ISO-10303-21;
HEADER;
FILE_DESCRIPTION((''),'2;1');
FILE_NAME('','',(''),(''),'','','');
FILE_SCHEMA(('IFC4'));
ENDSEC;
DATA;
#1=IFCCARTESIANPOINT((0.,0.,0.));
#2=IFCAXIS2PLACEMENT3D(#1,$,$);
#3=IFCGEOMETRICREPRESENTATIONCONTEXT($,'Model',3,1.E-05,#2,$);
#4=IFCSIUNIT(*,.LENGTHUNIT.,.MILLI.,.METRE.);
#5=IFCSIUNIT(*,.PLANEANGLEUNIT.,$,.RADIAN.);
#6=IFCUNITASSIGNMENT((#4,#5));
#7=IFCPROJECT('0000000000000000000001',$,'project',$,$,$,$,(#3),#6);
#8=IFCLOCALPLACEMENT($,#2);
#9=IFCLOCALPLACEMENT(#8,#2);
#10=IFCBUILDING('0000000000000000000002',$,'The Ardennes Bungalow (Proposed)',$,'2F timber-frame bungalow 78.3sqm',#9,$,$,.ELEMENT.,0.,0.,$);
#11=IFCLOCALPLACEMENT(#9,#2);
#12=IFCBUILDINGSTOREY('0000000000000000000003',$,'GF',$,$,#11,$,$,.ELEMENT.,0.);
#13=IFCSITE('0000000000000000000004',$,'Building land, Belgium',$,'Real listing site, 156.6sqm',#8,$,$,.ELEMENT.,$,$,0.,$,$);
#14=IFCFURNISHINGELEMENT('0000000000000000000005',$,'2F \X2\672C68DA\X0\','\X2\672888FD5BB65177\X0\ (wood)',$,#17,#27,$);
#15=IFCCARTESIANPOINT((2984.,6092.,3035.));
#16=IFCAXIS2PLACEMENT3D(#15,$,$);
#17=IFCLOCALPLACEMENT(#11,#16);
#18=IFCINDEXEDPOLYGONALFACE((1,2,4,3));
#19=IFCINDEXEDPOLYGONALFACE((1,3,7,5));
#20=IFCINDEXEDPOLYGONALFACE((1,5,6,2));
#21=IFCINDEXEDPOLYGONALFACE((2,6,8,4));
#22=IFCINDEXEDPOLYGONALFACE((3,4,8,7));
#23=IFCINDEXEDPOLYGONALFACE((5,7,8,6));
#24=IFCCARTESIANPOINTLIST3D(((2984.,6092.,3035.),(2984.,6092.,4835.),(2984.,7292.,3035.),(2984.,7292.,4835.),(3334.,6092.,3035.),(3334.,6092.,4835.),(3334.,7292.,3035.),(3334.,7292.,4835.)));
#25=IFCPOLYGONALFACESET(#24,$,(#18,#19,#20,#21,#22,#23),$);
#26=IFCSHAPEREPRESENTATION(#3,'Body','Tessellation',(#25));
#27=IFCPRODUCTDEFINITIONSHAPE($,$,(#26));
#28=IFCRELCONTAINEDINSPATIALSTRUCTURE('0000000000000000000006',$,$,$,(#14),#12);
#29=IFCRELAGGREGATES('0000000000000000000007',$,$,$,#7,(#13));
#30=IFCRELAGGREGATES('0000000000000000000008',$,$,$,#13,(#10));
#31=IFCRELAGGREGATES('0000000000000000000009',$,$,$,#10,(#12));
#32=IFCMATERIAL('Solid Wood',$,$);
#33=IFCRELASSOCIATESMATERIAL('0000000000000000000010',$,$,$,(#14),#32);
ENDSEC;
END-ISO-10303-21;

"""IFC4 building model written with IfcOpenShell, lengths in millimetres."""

from ifc_helpers import new_model, si_unit, frame, frame_2d, origin, place, context, project, spatial, rectangle, extrude, material, element, save


model = new_model("IFC4")

# Units and contexts
model_context = context("Model", 3, precision=1e-05, world=origin())
ifc_project = project(units=[si_unit("LENGTHUNIT", "METRE", prefix="MILLI"), si_unit("PLANEANGLEUNIT", "RADIAN")], contexts=[model_context])

# Site, building, storey
site_placement = place(None, origin())
site = spatial("IfcSite", under=ifc_project, at=site_placement, Name="Building land, Belgium", ObjectType="Real listing site, 156.6sqm", CompositionType="ELEMENT", RefElevation=0.0)
building_placement = place(site_placement, origin())
building = spatial("IfcBuilding", under=site, at=building_placement, Name="The Ardennes Bungalow (Proposed)", ObjectType="2F timber-frame bungalow 78.3sqm", CompositionType="ELEMENT", ElevationOfRefHeight=0.0, ElevationOfTerrain=0.0)
storey_placement = place(building_placement, origin())
storey = spatial("IfcBuildingStorey", under=building, at=storey_placement, Name="GF", CompositionType="ELEMENT", Elevation=0.0)

# Shared definitions
ifc_material_1 = material(Name="Solid Wood")

# Furnishing element
furnishing_1_placement = place(storey_placement, frame((2984.0, 6092.0, 3035.0)))
element("IfcFurnishingElement", 1, at=furnishing_1_placement, inside=storey, material=ifc_material_1, Name="2F 本棚", Description="木製家具 (wood)", context=model_context, shape_type="SweptSolid", body=[
    extrude(rectangle(XDim=350.0, YDim=1200.0, at=frame_2d((175.0, 600.0))), frame((2984.0, 6092.0, 3035.0)), (0.0, 0.0, 1.0), 1800.0),
])

save(model, "model.ifc")
